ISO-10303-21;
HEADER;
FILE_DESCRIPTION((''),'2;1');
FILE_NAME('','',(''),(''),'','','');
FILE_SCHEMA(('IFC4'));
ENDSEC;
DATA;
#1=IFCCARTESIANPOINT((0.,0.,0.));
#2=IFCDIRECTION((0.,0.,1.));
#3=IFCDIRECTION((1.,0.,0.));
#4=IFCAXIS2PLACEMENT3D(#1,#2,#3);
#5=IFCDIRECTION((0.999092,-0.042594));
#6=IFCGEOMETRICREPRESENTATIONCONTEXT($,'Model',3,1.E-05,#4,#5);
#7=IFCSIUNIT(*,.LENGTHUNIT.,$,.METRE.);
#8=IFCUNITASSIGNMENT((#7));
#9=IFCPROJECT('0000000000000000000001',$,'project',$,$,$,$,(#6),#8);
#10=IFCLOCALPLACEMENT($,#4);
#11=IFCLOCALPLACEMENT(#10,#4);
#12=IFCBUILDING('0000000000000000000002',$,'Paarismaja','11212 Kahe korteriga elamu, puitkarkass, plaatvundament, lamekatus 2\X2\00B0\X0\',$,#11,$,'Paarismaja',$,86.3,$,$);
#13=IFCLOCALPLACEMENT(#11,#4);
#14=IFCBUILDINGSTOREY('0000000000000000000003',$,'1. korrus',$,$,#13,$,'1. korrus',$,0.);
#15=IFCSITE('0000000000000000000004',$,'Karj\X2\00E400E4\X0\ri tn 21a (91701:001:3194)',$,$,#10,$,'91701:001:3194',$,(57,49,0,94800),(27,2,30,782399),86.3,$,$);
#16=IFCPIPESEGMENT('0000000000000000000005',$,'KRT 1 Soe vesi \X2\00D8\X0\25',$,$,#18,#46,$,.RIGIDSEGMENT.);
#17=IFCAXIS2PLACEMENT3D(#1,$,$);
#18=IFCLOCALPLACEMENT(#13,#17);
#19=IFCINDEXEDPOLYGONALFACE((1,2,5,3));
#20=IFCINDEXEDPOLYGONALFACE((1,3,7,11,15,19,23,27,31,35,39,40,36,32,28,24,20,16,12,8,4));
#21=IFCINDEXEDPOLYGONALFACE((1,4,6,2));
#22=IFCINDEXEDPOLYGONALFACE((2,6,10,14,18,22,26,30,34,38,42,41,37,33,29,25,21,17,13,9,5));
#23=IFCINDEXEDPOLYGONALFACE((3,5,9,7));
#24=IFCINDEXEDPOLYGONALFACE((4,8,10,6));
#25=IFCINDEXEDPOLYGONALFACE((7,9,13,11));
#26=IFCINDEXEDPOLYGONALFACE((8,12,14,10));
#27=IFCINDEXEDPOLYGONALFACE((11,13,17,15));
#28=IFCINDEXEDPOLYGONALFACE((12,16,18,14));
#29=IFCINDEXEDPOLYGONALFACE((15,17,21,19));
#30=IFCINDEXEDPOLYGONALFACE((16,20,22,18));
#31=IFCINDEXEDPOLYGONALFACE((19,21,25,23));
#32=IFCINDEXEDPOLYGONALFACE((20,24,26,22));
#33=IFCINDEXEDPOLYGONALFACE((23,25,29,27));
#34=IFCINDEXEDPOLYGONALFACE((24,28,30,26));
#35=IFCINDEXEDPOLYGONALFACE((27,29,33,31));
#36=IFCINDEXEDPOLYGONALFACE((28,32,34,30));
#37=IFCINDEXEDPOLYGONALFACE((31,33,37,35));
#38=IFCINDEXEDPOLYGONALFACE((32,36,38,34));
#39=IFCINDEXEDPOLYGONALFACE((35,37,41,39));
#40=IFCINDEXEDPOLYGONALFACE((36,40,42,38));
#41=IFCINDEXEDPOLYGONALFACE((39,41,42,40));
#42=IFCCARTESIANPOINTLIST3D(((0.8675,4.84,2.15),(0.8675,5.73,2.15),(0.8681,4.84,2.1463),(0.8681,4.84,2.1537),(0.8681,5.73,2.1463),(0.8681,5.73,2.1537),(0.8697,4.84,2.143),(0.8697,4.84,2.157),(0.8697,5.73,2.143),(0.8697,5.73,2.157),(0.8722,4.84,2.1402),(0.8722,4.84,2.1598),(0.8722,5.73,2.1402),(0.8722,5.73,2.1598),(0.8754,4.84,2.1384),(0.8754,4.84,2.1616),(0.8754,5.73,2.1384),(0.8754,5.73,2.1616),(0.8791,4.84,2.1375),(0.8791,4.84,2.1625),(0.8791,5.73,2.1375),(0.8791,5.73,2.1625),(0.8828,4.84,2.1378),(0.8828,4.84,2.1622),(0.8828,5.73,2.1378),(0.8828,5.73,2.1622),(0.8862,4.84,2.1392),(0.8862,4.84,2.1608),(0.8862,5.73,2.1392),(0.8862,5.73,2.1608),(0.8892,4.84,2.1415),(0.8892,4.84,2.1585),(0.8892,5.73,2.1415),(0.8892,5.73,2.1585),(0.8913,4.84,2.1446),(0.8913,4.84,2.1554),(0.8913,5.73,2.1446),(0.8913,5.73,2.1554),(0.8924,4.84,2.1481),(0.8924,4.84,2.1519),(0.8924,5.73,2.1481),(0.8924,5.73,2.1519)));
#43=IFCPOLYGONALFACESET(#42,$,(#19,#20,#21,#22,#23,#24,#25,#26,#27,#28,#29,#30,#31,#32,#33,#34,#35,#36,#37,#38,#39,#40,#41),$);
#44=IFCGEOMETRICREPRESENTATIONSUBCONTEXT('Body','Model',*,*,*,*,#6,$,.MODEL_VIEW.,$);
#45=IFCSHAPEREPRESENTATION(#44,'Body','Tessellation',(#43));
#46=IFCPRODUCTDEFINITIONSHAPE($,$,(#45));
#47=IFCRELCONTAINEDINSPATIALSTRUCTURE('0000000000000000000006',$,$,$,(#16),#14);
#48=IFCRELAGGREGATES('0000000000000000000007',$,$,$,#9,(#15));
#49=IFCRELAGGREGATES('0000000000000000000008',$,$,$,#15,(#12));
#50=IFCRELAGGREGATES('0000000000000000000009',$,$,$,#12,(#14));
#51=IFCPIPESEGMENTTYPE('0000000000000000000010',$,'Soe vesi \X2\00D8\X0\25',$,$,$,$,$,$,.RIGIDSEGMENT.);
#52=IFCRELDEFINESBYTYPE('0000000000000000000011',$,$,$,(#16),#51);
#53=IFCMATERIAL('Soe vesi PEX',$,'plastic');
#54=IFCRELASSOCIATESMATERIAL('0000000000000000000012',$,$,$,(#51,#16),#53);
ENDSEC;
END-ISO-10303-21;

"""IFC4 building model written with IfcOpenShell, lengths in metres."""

from ifc_helpers import new_model, si_unit, direction, frame, origin_with_axes, place, context, subcontext, project, spatial, circle, extrude, material, type_object, element, save


model = new_model("IFC4")

# Units and contexts
model_context = context("Model", 3, precision=1e-05, world=origin_with_axes(), true_north=direction((0.999092, -0.042594)))
body_context = subcontext(model_context, "Body", "Model", "MODEL_VIEW")
ifc_project = project(units=[si_unit("LENGTHUNIT", "METRE")], contexts=[model_context])

# Site, building, storey
site_placement = place(None, origin_with_axes())
site = spatial("IfcSite", under=ifc_project, at=site_placement, Name="Karjääri tn 21a (91701:001:3194)", LongName="91701:001:3194", RefLatitude=(57, 49, 0, 94800), RefLongitude=(27, 2, 30, 782399), RefElevation=86.3)
building_placement = place(site_placement, origin_with_axes())
building = spatial("IfcBuilding", under=site, at=building_placement, Name="Paarismaja", Description="11212 Kahe korteriga elamu, puitkarkass, plaatvundament, lamekatus 2°", LongName="Paarismaja", ElevationOfRefHeight=86.3)
storey_placement = place(building_placement, origin_with_axes())
storey = spatial("IfcBuildingStorey", under=building, at=storey_placement, Name="1. korrus", LongName="1. korrus", Elevation=0.0)

# Shared definitions
ifc_material_1 = material(Name="Soe vesi PEX", Category="plastic")

# Pipe segment
pipe_segment_type_1 = type_object("IfcPipeSegmentType", Name="Soe vesi Ø25", PredefinedType="RIGIDSEGMENT", material=ifc_material_1)
pipe_segment_1_placement = place(storey_placement, frame((0.88, 5.73, 2.15), z_axis=(0.0, -1.0, 0.0), x_axis=(-1.0, 0.0, 0.0)))
element("IfcPipeSegment", 1, at=pipe_segment_1_placement, inside=storey, type_object=pipe_segment_type_1, material=ifc_material_1, Name="KRT 1 Soe vesi Ø25", PredefinedType="RIGIDSEGMENT", context=body_context, shape_type="SweptSolid", body=[
    extrude(circle(Radius=0.0125), origin_with_axes(), (0.0, 0.0, 1.0), 0.89),
])

save(model, "model.ifc")
